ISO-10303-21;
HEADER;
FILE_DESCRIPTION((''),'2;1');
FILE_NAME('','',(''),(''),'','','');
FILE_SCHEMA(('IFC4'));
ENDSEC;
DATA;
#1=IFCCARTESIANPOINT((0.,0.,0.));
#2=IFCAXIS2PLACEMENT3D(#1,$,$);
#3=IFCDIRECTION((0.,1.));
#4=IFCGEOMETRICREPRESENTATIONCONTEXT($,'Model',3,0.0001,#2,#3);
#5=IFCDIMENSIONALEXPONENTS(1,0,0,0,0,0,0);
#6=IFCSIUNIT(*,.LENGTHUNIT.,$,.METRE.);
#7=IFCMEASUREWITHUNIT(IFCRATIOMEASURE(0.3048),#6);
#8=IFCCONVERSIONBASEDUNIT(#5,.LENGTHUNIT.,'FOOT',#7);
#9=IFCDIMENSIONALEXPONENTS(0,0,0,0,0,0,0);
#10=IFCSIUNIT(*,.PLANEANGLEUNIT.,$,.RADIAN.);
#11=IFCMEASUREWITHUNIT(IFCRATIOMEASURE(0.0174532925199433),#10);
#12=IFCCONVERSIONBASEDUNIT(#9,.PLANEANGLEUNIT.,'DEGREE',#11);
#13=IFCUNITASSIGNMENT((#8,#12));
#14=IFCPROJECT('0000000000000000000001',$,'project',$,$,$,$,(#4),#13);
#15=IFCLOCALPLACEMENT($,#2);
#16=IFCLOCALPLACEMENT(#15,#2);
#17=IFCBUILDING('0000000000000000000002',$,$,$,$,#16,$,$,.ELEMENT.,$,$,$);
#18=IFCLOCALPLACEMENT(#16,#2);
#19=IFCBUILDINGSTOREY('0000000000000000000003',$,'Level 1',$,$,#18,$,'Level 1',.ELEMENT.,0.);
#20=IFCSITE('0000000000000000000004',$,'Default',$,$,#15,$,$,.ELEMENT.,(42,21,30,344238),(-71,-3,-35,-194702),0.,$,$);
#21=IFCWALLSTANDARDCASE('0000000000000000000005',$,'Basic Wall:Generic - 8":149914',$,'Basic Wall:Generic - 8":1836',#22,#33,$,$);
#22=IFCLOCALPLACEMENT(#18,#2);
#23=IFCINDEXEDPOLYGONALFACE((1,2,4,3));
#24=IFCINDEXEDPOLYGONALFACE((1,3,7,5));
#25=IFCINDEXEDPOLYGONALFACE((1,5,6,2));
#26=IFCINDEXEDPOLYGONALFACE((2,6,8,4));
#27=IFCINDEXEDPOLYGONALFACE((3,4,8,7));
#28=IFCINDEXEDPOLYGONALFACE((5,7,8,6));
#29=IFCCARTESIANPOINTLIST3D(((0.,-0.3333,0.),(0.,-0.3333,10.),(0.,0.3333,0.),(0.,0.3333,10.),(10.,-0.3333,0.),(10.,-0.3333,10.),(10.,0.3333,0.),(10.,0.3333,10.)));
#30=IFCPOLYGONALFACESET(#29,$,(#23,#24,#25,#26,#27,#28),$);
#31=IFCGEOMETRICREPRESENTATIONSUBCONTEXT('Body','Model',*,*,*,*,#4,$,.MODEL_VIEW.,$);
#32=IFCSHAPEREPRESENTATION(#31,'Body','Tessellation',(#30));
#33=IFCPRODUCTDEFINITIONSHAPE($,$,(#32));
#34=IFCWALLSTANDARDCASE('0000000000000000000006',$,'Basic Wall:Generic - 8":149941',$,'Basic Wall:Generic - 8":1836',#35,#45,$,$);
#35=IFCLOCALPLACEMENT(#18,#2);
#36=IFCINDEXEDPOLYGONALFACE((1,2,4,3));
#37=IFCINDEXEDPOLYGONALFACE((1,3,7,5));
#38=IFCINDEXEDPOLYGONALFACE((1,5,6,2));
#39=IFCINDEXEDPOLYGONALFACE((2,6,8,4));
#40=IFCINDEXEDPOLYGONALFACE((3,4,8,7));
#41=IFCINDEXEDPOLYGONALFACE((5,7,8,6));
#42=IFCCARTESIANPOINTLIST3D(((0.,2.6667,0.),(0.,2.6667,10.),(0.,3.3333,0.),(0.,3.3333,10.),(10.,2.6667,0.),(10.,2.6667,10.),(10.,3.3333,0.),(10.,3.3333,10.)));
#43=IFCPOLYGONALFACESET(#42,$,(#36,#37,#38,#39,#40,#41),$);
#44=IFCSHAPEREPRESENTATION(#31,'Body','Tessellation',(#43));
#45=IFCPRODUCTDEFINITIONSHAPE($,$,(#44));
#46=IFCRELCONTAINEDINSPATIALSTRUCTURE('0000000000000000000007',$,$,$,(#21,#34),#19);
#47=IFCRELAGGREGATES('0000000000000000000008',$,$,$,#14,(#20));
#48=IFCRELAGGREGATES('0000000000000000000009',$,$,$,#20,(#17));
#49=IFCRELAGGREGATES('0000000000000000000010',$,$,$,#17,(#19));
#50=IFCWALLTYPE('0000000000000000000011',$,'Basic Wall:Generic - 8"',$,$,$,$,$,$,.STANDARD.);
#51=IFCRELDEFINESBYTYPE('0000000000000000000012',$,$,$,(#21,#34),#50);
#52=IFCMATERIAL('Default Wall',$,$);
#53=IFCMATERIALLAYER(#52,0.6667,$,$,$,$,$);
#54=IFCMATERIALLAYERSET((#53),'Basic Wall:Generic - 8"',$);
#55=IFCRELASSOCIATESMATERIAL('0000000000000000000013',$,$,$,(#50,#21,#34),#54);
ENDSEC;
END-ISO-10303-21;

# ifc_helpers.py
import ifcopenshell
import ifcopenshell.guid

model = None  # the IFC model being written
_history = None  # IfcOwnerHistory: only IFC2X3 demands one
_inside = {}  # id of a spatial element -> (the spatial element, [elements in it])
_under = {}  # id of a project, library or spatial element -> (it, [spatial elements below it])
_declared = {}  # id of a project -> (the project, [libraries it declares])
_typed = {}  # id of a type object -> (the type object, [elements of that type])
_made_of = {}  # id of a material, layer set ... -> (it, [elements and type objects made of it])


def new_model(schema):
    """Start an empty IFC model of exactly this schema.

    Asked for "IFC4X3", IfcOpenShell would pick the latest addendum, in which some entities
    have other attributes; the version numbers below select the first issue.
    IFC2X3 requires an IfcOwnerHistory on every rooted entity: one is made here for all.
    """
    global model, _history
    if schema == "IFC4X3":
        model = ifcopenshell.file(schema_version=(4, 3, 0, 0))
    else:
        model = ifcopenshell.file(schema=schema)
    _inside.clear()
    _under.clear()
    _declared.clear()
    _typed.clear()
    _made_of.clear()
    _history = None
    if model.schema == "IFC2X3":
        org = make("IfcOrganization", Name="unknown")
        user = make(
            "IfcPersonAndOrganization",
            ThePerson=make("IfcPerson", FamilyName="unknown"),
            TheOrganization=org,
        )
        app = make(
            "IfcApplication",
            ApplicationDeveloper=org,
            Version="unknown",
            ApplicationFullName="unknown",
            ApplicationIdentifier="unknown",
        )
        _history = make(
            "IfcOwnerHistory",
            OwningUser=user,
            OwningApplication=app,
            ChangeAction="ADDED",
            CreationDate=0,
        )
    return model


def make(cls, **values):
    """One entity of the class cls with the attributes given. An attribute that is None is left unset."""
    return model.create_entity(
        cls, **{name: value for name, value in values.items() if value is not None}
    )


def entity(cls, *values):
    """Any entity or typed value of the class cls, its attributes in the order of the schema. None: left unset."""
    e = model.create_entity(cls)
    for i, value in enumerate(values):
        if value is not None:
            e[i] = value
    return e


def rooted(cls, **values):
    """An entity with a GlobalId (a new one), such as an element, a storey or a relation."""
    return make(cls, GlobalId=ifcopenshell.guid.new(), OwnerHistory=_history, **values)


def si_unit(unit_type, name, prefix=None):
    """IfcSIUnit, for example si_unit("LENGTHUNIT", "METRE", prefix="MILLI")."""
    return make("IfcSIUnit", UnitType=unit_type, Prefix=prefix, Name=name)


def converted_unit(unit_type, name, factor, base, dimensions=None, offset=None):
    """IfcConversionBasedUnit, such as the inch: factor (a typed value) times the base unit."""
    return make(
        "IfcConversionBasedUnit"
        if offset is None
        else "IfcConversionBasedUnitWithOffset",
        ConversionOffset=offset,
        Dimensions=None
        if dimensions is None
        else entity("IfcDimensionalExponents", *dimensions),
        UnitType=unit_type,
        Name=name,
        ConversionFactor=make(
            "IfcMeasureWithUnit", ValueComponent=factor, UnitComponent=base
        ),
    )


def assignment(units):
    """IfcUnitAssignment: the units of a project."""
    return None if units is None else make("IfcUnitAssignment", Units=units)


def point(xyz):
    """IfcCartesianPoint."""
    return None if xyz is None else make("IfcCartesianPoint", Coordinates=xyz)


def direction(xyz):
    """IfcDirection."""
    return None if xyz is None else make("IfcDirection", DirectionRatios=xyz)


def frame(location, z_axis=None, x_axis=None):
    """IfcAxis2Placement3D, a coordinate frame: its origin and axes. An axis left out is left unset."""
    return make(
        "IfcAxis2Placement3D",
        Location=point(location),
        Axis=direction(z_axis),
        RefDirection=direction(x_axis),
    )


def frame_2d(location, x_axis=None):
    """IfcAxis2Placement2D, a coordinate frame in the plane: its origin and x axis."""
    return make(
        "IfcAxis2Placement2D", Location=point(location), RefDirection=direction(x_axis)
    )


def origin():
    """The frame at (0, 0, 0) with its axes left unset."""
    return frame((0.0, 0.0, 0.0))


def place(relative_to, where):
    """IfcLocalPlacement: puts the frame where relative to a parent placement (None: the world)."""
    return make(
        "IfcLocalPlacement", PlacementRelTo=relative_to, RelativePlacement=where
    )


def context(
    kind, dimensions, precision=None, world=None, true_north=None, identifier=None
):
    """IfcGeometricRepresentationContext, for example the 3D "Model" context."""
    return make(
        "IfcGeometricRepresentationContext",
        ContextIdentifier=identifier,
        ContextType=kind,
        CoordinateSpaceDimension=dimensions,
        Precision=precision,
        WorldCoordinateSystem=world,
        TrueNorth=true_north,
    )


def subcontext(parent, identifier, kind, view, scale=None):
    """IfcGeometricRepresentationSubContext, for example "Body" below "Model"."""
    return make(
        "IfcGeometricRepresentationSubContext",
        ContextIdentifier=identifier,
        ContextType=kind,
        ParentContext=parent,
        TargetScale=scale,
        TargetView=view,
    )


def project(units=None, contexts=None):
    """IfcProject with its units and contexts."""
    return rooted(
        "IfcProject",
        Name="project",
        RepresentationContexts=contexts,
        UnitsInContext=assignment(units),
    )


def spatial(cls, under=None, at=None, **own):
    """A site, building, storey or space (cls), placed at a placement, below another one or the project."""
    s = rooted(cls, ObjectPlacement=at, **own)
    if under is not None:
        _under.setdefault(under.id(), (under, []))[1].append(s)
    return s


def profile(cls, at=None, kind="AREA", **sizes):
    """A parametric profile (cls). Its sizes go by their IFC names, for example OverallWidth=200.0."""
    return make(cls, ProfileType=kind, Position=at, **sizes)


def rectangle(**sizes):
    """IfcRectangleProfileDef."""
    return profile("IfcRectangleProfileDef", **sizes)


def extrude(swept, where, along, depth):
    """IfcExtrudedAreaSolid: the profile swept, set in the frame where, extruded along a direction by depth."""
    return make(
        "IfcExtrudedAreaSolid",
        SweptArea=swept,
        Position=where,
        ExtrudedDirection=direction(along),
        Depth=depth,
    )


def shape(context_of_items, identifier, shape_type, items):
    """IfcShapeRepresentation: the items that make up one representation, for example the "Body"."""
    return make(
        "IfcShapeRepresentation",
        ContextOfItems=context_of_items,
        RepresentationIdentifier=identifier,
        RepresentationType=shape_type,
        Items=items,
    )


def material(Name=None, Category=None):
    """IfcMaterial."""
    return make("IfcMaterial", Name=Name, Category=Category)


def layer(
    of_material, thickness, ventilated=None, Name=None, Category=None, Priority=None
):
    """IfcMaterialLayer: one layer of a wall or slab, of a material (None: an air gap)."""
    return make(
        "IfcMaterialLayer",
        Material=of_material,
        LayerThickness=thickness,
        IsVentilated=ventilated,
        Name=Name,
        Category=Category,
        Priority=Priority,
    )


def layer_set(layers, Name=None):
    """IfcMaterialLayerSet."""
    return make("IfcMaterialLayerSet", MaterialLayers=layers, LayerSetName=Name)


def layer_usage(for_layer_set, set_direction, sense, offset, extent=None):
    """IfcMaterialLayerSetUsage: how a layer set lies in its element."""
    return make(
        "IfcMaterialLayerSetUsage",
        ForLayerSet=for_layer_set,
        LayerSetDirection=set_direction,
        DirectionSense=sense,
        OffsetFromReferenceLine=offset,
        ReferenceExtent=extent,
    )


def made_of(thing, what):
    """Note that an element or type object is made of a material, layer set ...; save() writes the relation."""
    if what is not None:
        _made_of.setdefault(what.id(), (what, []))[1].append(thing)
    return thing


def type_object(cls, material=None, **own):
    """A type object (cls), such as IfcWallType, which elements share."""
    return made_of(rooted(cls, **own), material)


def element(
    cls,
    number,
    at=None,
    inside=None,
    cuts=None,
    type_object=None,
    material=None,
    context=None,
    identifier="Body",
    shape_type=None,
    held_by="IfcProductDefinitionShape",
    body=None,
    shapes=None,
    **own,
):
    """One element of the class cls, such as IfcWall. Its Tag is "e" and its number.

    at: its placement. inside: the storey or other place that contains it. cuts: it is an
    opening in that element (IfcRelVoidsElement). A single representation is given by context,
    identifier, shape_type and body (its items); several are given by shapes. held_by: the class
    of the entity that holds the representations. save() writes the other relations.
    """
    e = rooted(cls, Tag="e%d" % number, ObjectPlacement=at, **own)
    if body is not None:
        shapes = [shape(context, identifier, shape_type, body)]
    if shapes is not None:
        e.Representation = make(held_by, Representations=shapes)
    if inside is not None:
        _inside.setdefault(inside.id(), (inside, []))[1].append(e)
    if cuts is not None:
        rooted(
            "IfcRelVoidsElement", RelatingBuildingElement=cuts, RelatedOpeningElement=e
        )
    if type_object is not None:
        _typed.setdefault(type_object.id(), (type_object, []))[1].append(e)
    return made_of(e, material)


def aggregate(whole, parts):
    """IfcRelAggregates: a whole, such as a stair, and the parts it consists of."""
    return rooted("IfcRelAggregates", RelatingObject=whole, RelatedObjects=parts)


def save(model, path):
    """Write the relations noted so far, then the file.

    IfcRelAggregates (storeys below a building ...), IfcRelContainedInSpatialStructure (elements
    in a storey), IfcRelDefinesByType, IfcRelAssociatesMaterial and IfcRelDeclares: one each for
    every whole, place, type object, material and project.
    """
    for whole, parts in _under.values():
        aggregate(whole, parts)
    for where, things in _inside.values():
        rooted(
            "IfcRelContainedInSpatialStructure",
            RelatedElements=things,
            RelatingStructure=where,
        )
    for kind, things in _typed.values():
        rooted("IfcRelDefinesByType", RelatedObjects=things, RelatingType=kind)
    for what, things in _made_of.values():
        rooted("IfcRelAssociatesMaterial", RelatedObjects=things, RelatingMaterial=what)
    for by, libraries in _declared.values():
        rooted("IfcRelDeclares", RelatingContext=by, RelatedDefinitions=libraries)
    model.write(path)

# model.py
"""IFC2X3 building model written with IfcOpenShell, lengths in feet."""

from ifc_helpers import new_model, entity, si_unit, converted_unit, direction, frame, frame_2d, origin, place, context, subcontext, project, spatial, rectangle, extrude, material, layer, layer_set, layer_usage, type_object, element, save


model = new_model("IFC2X3")

# Units and contexts
model_context = context("Model", 3, precision=0.0001, world=origin(), true_north=direction((0.0, 1.0)))
body_context = subcontext(model_context, "Body", "Model", "MODEL_VIEW")
ifc_project = project(units=[converted_unit("LENGTHUNIT", "FOOT", entity("IfcRatioMeasure", 0.3048), si_unit("LENGTHUNIT", "METRE"), dimensions=[1, 0, 0, 0, 0, 0, 0]), converted_unit("PLANEANGLEUNIT", "DEGREE", entity("IfcRatioMeasure", 0.0174532925199433), si_unit("PLANEANGLEUNIT", "RADIAN"), dimensions=[0, 0, 0, 0, 0, 0, 0])], contexts=[model_context])

# Site, building, storey
site_placement = place(None, origin())
site = spatial("IfcSite", under=ifc_project, at=site_placement, Name="Default", CompositionType="ELEMENT", RefLatitude=(42, 21, 30, 344238), RefLongitude=(-71, -3, -35, -194702), RefElevation=0.0)
building_placement = place(site_placement, origin())
building = spatial("IfcBuilding", under=site, at=building_placement, CompositionType="ELEMENT")
storey_placement = place(building_placement, origin())
storey = spatial("IfcBuildingStorey", under=building, at=storey_placement, Name="Level 1", LongName="Level 1", CompositionType="ELEMENT", Elevation=0.0)

# Walls
ifc_material = material(Name="Default Wall")
ifc_layer = layer(ifc_material, 0.6667)
ifc_layer_set = layer_set([ifc_layer], Name="Basic Wall:Generic - 8\"")
ifc_layer_usage_1 = layer_usage(ifc_layer_set, "AXIS2", "NEGATIVE", 0.3333)
wall_type = type_object("IfcWallType", Name="Basic Wall:Generic - 8\"", PredefinedType="STANDARD", material=ifc_layer_set)
wall_1_placement = place(storey_placement, origin())
element("IfcWallStandardCase", 1, at=wall_1_placement, inside=storey, type_object=wall_type, material=ifc_layer_usage_1, Name="Basic Wall:Generic - 8\":149914", ObjectType="Basic Wall:Generic - 8\":1836", context=body_context, shape_type="SweptSolid", body=[
    extrude(rectangle(XDim=10.0, YDim=0.6667, at=frame_2d((5.0, 0.0), x_axis=(-1.0, 0.0))), origin(), (0.0, 0.0, 1.0), 10.0),
])
ifc_layer_usage_2 = layer_usage(ifc_layer_set, "AXIS2", "NEGATIVE", 0.3333)
wall_2_placement = place(storey_placement, frame((0.0, 3.0, 0.0)))
element("IfcWallStandardCase", 2, at=wall_2_placement, inside=storey, type_object=wall_type, material=ifc_layer_usage_2, Name="Basic Wall:Generic - 8\":149941", ObjectType="Basic Wall:Generic - 8\":1836", context=body_context, shape_type="SweptSolid", body=[
    extrude(rectangle(XDim=10.0, YDim=0.6667, at=frame_2d((5.0, 0.0), x_axis=(-1.0, 0.0))), origin(), (0.0, 0.0, 1.0), 10.0),
])

save(model, "model.ifc")
